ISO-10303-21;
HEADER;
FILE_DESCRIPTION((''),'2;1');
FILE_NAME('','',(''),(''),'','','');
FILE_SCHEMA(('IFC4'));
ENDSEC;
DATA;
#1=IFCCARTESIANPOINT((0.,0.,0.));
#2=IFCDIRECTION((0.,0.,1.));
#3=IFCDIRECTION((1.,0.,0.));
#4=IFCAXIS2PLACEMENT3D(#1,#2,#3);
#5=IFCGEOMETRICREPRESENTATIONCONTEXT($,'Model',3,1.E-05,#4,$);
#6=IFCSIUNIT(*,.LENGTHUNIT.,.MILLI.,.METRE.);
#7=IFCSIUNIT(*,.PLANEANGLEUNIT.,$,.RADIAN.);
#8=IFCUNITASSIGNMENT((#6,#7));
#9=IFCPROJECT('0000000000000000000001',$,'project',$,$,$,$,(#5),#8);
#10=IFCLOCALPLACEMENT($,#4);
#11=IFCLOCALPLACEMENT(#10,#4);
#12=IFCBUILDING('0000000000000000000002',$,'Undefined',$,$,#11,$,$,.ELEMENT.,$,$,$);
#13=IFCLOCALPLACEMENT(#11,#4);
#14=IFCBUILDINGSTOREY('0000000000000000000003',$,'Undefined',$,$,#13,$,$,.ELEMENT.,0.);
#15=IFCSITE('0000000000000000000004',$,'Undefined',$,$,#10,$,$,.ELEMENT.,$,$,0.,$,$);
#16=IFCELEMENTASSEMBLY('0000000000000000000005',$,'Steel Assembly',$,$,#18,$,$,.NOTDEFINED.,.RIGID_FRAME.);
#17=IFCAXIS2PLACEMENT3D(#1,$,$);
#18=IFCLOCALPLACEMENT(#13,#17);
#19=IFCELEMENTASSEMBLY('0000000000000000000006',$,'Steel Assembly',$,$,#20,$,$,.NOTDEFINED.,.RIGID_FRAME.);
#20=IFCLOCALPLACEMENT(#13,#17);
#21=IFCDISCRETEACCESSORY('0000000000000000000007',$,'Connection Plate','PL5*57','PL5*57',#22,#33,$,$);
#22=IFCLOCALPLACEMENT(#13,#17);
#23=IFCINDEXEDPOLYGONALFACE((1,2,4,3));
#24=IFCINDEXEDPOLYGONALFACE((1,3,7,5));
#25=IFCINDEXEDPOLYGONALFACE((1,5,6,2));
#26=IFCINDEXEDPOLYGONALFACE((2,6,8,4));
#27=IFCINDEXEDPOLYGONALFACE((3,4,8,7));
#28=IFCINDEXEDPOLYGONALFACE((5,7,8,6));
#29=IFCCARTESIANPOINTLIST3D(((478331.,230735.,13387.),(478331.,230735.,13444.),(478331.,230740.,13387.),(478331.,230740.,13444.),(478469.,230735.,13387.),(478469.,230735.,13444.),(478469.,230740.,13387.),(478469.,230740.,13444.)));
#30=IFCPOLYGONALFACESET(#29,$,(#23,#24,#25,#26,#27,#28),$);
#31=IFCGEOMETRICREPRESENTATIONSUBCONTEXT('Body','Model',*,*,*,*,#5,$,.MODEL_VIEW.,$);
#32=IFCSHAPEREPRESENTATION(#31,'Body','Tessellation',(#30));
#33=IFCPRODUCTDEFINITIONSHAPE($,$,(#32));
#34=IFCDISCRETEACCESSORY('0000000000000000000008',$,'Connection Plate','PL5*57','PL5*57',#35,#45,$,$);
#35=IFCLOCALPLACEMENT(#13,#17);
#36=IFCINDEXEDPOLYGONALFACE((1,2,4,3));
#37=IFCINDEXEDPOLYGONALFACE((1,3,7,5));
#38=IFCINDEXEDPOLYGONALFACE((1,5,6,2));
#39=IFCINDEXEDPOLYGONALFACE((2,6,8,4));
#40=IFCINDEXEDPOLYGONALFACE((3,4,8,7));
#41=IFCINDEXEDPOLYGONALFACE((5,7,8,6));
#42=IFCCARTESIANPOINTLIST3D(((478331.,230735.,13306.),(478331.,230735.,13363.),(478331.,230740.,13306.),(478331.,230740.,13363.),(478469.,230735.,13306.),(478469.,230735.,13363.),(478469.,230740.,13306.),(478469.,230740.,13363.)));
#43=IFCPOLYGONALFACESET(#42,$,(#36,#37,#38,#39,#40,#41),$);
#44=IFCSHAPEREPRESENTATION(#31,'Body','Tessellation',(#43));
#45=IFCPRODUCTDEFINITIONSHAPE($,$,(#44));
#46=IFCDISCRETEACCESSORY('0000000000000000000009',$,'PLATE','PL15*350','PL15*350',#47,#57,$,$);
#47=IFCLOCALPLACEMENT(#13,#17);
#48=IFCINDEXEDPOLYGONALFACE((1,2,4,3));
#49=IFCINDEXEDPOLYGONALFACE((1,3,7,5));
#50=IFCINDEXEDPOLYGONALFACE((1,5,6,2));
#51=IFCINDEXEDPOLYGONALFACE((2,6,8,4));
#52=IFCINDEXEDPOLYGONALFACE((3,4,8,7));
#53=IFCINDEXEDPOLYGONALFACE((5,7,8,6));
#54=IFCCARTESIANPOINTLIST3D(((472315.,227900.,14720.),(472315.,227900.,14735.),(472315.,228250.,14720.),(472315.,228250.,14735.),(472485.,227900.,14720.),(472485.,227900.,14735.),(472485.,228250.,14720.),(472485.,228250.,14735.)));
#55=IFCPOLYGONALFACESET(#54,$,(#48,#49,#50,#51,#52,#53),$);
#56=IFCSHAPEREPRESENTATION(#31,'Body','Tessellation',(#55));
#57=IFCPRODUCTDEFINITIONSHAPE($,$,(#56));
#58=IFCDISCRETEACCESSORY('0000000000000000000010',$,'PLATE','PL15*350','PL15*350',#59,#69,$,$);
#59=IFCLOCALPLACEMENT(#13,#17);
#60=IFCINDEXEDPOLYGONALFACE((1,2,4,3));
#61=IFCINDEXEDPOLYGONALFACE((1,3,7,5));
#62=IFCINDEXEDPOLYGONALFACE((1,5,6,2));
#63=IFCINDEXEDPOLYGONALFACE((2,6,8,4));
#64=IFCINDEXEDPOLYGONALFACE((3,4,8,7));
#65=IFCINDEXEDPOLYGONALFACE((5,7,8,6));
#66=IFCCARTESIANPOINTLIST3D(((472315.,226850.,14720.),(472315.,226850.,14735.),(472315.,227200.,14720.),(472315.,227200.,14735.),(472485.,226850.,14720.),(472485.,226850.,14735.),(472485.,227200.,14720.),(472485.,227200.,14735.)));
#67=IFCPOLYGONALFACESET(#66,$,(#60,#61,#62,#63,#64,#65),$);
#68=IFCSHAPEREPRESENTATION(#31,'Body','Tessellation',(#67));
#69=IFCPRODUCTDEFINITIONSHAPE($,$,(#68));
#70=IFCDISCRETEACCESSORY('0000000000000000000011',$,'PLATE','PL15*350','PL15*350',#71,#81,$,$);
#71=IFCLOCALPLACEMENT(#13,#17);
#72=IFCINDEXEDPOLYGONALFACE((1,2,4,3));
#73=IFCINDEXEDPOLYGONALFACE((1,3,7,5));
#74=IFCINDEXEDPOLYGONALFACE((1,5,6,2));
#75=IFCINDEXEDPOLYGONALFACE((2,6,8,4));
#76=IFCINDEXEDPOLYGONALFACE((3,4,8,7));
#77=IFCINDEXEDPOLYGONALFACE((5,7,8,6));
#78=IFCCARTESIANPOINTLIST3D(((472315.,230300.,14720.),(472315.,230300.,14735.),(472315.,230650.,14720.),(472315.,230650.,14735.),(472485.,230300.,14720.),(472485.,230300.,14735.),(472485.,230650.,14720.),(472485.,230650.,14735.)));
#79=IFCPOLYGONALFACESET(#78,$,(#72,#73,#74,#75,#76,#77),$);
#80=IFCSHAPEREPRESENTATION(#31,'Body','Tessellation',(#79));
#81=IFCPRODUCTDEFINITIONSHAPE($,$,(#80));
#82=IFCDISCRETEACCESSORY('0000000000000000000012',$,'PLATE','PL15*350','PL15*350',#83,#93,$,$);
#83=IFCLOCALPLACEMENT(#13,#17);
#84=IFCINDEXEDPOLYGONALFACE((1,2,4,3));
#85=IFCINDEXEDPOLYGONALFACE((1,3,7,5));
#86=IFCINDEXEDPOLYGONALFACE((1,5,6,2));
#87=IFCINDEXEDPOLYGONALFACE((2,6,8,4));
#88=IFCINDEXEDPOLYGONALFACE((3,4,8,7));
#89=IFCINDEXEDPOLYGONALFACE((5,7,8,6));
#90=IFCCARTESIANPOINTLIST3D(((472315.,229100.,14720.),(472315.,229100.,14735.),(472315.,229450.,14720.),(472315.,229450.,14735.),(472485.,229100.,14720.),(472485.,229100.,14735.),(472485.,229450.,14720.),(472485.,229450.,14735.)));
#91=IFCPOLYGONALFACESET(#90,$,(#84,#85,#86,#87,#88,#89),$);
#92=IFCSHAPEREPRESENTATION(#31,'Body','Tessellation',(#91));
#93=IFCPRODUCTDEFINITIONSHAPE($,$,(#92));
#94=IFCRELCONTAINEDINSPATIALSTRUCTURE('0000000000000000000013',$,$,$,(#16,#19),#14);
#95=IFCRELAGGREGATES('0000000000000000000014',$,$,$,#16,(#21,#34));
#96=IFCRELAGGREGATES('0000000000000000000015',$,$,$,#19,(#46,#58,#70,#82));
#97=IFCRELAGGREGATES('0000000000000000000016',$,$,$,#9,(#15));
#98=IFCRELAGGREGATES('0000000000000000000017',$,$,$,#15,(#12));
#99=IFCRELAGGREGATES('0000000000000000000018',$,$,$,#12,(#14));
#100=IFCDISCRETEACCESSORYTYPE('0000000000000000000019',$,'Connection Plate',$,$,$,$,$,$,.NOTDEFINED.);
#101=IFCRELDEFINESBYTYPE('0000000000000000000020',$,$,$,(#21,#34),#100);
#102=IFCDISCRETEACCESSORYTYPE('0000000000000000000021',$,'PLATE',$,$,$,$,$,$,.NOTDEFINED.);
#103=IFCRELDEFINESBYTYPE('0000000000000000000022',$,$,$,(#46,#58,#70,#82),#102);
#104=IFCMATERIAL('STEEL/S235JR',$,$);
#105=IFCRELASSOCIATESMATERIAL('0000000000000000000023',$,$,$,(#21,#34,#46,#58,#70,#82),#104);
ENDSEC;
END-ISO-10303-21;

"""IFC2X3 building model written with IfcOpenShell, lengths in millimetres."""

from ifc_helpers import new_model, si_unit, frame, origin_with_axes, place, context, subcontext, project, spatial, polyline, outline, extrude, material, type_object, element, aggregate, save


model = new_model("IFC2X3")

# Units and contexts
model_context = context("Model", 3, precision=1e-05, world=origin_with_axes())
body_context = subcontext(model_context, "Body", "Model", "MODEL_VIEW")
ifc_project = project(units=[si_unit("LENGTHUNIT", "METRE", prefix="MILLI"), si_unit("PLANEANGLEUNIT", "RADIAN")], contexts=[model_context])

# Site, building, storey
site_placement = place(None, origin_with_axes())
site = spatial("IfcSite", under=ifc_project, at=site_placement, Name="Undefined", CompositionType="ELEMENT", RefElevation=0.0)
building_placement = place(site_placement, origin_with_axes())
building = spatial("IfcBuilding", under=site, at=building_placement, Name="Undefined", CompositionType="ELEMENT")
storey_placement = place(building_placement, origin_with_axes())
storey = spatial("IfcBuildingStorey", under=building, at=storey_placement, Name="Undefined", CompositionType="ELEMENT", Elevation=0.0)

# Shared definitions
ifc_material_1 = material(Name="STEEL/S235JR")

# Element assemblies
assembly_1_placement = place(storey_placement, origin_with_axes())
assembly_1 = element("IfcElementAssembly", 1, at=assembly_1_placement, inside=storey, Name="Steel Assembly", AssemblyPlace="NOTDEFINED", PredefinedType="RIGID_FRAME")
assembly_2_placement = place(storey_placement, origin_with_axes())
assembly_2 = element("IfcElementAssembly", 2, at=assembly_2_placement, inside=storey, Name="Steel Assembly", AssemblyPlace="NOTDEFINED", PredefinedType="RIGID_FRAME")
discrete_accessory_type_1 = type_object("IfcDiscreteAccessoryType", Name="Connection Plate")

# Discrete accessories
discrete_accessory_1_placement = place(assembly_1_placement, frame((478469.0, 230737.5, 13444.0), z_axis=(0.0, -1.0, 0.0), x_axis=(-1.0, 0.0, 0.0)))
discrete_accessory_1 = element("IfcDiscreteAccessory", 3, at=discrete_accessory_1_placement, type_object=discrete_accessory_type_1, material=ifc_material_1, Name="Connection Plate", Description="PL5*57", ObjectType="PL5*57", context=body_context, shape_type="SweptSolid", body=[
    extrude(outline(polyline([(0.0, 0.0), (138.0, 0.0), (138.0, 57.0), (0.0, 57.0), (0.0, 0.0)])), frame((0.0, 0.0, -2.5), z_axis=(0.0, 0.0, 1.0), x_axis=(1.0, 0.0, 0.0)), (0.0, 0.0, 1.0), 5.0),
])
discrete_accessory_2_placement = place(assembly_1_placement, frame((478469.0, 230737.5, 13363.0), z_axis=(0.0, -1.0, 0.0), x_axis=(-1.0, 0.0, 0.0)))
discrete_accessory_2 = element("IfcDiscreteAccessory", 4, at=discrete_accessory_2_placement, type_object=discrete_accessory_type_1, material=ifc_material_1, Name="Connection Plate", Description="PL5*57", ObjectType="PL5*57", context=body_context, shape_type="SweptSolid", body=[
    extrude(outline(polyline([(0.0, 0.0), (138.0, 0.0), (138.0, 57.0), (0.0, 57.0), (0.0, 0.0)])), frame((0.0, 0.0, -2.5), z_axis=(0.0, 0.0, 1.0), x_axis=(1.0, 0.0, 0.0)), (0.0, 0.0, 1.0), 5.0),
])
aggregate(assembly_1, [discrete_accessory_1, discrete_accessory_2])
discrete_accessory_type_2 = type_object("IfcDiscreteAccessoryType", Name="PLATE")
discrete_accessory_3_placement = place(assembly_2_placement, frame((472485.0, 228075.0, 14727.5), z_axis=(0.0, 0.0, 1.0), x_axis=(-1.0, 0.0, 0.0)))
discrete_accessory_3 = element("IfcDiscreteAccessory", 5, at=discrete_accessory_3_placement, type_object=discrete_accessory_type_2, material=ifc_material_1, Name="PLATE", Description="PL15*350", ObjectType="PL15*350", context=body_context, shape_type="SweptSolid", body=[
    extrude(outline(polyline([(170.0, -175.0), (0.0, -175.0), (0.0, 175.0), (170.0, 175.0), (170.0, -175.0)])), frame((0.0, 0.0, -7.5), z_axis=(0.0, 0.0, 1.0), x_axis=(1.0, 0.0, 0.0)), (0.0, 0.0, 1.0), 15.0),
])
discrete_accessory_4_placement = place(assembly_2_placement, frame((472485.0, 227025.0, 14727.5), z_axis=(0.0, 0.0, 1.0), x_axis=(-1.0, 0.0, 0.0)))
discrete_accessory_4 = element("IfcDiscreteAccessory", 6, at=discrete_accessory_4_placement, type_object=discrete_accessory_type_2, material=ifc_material_1, Name="PLATE", Description="PL15*350", ObjectType="PL15*350", context=body_context, shape_type="SweptSolid", body=[
    extrude(outline(polyline([(170.0, -175.0), (0.0, -175.0), (0.0, 175.0), (170.0, 175.0), (170.0, -175.0)])), frame((0.0, 0.0, -7.5), z_axis=(0.0, 0.0, 1.0), x_axis=(1.0, 0.0, 0.0)), (0.0, 0.0, 1.0), 15.0),
])
discrete_accessory_5_placement = place(assembly_2_placement, frame((472485.0, 230475.0, 14727.5), z_axis=(0.0, 0.0, 1.0), x_axis=(-1.0, 0.0, 0.0)))
discrete_accessory_5 = element("IfcDiscreteAccessory", 7, at=discrete_accessory_5_placement, type_object=discrete_accessory_type_2, material=ifc_material_1, Name="PLATE", Description="PL15*350", ObjectType="PL15*350", context=body_context, shape_type="SweptSolid", body=[
    extrude(outline(polyline([(170.0, -175.0), (0.0, -175.0), (0.0, 175.0), (170.0, 175.0), (170.0, -175.0)])), frame((0.0, 0.0, -7.5), z_axis=(0.0, 0.0, 1.0), x_axis=(1.0, 0.0, 0.0)), (0.0, 0.0, 1.0), 15.0),
])
discrete_accessory_6_placement = place(assembly_2_placement, frame((472485.0, 229275.0, 14727.5), z_axis=(0.0, 0.0, 1.0), x_axis=(-1.0, 0.0, 0.0)))
discrete_accessory_6 = element("IfcDiscreteAccessory", 8, at=discrete_accessory_6_placement, type_object=discrete_accessory_type_2, material=ifc_material_1, Name="PLATE", Description="PL15*350", ObjectType="PL15*350", context=body_context, shape_type="SweptSolid", body=[
    extrude(outline(polyline([(170.0, -175.0), (0.0, -175.0), (0.0, 175.0), (170.0, 175.0), (170.0, -175.0)])), frame((0.0, 0.0, -7.5), z_axis=(0.0, 0.0, 1.0), x_axis=(1.0, 0.0, 0.0)), (0.0, 0.0, 1.0), 15.0),
])
aggregate(assembly_2, [discrete_accessory_3, discrete_accessory_4, discrete_accessory_5, discrete_accessory_6])

save(model, "model.ifc")
